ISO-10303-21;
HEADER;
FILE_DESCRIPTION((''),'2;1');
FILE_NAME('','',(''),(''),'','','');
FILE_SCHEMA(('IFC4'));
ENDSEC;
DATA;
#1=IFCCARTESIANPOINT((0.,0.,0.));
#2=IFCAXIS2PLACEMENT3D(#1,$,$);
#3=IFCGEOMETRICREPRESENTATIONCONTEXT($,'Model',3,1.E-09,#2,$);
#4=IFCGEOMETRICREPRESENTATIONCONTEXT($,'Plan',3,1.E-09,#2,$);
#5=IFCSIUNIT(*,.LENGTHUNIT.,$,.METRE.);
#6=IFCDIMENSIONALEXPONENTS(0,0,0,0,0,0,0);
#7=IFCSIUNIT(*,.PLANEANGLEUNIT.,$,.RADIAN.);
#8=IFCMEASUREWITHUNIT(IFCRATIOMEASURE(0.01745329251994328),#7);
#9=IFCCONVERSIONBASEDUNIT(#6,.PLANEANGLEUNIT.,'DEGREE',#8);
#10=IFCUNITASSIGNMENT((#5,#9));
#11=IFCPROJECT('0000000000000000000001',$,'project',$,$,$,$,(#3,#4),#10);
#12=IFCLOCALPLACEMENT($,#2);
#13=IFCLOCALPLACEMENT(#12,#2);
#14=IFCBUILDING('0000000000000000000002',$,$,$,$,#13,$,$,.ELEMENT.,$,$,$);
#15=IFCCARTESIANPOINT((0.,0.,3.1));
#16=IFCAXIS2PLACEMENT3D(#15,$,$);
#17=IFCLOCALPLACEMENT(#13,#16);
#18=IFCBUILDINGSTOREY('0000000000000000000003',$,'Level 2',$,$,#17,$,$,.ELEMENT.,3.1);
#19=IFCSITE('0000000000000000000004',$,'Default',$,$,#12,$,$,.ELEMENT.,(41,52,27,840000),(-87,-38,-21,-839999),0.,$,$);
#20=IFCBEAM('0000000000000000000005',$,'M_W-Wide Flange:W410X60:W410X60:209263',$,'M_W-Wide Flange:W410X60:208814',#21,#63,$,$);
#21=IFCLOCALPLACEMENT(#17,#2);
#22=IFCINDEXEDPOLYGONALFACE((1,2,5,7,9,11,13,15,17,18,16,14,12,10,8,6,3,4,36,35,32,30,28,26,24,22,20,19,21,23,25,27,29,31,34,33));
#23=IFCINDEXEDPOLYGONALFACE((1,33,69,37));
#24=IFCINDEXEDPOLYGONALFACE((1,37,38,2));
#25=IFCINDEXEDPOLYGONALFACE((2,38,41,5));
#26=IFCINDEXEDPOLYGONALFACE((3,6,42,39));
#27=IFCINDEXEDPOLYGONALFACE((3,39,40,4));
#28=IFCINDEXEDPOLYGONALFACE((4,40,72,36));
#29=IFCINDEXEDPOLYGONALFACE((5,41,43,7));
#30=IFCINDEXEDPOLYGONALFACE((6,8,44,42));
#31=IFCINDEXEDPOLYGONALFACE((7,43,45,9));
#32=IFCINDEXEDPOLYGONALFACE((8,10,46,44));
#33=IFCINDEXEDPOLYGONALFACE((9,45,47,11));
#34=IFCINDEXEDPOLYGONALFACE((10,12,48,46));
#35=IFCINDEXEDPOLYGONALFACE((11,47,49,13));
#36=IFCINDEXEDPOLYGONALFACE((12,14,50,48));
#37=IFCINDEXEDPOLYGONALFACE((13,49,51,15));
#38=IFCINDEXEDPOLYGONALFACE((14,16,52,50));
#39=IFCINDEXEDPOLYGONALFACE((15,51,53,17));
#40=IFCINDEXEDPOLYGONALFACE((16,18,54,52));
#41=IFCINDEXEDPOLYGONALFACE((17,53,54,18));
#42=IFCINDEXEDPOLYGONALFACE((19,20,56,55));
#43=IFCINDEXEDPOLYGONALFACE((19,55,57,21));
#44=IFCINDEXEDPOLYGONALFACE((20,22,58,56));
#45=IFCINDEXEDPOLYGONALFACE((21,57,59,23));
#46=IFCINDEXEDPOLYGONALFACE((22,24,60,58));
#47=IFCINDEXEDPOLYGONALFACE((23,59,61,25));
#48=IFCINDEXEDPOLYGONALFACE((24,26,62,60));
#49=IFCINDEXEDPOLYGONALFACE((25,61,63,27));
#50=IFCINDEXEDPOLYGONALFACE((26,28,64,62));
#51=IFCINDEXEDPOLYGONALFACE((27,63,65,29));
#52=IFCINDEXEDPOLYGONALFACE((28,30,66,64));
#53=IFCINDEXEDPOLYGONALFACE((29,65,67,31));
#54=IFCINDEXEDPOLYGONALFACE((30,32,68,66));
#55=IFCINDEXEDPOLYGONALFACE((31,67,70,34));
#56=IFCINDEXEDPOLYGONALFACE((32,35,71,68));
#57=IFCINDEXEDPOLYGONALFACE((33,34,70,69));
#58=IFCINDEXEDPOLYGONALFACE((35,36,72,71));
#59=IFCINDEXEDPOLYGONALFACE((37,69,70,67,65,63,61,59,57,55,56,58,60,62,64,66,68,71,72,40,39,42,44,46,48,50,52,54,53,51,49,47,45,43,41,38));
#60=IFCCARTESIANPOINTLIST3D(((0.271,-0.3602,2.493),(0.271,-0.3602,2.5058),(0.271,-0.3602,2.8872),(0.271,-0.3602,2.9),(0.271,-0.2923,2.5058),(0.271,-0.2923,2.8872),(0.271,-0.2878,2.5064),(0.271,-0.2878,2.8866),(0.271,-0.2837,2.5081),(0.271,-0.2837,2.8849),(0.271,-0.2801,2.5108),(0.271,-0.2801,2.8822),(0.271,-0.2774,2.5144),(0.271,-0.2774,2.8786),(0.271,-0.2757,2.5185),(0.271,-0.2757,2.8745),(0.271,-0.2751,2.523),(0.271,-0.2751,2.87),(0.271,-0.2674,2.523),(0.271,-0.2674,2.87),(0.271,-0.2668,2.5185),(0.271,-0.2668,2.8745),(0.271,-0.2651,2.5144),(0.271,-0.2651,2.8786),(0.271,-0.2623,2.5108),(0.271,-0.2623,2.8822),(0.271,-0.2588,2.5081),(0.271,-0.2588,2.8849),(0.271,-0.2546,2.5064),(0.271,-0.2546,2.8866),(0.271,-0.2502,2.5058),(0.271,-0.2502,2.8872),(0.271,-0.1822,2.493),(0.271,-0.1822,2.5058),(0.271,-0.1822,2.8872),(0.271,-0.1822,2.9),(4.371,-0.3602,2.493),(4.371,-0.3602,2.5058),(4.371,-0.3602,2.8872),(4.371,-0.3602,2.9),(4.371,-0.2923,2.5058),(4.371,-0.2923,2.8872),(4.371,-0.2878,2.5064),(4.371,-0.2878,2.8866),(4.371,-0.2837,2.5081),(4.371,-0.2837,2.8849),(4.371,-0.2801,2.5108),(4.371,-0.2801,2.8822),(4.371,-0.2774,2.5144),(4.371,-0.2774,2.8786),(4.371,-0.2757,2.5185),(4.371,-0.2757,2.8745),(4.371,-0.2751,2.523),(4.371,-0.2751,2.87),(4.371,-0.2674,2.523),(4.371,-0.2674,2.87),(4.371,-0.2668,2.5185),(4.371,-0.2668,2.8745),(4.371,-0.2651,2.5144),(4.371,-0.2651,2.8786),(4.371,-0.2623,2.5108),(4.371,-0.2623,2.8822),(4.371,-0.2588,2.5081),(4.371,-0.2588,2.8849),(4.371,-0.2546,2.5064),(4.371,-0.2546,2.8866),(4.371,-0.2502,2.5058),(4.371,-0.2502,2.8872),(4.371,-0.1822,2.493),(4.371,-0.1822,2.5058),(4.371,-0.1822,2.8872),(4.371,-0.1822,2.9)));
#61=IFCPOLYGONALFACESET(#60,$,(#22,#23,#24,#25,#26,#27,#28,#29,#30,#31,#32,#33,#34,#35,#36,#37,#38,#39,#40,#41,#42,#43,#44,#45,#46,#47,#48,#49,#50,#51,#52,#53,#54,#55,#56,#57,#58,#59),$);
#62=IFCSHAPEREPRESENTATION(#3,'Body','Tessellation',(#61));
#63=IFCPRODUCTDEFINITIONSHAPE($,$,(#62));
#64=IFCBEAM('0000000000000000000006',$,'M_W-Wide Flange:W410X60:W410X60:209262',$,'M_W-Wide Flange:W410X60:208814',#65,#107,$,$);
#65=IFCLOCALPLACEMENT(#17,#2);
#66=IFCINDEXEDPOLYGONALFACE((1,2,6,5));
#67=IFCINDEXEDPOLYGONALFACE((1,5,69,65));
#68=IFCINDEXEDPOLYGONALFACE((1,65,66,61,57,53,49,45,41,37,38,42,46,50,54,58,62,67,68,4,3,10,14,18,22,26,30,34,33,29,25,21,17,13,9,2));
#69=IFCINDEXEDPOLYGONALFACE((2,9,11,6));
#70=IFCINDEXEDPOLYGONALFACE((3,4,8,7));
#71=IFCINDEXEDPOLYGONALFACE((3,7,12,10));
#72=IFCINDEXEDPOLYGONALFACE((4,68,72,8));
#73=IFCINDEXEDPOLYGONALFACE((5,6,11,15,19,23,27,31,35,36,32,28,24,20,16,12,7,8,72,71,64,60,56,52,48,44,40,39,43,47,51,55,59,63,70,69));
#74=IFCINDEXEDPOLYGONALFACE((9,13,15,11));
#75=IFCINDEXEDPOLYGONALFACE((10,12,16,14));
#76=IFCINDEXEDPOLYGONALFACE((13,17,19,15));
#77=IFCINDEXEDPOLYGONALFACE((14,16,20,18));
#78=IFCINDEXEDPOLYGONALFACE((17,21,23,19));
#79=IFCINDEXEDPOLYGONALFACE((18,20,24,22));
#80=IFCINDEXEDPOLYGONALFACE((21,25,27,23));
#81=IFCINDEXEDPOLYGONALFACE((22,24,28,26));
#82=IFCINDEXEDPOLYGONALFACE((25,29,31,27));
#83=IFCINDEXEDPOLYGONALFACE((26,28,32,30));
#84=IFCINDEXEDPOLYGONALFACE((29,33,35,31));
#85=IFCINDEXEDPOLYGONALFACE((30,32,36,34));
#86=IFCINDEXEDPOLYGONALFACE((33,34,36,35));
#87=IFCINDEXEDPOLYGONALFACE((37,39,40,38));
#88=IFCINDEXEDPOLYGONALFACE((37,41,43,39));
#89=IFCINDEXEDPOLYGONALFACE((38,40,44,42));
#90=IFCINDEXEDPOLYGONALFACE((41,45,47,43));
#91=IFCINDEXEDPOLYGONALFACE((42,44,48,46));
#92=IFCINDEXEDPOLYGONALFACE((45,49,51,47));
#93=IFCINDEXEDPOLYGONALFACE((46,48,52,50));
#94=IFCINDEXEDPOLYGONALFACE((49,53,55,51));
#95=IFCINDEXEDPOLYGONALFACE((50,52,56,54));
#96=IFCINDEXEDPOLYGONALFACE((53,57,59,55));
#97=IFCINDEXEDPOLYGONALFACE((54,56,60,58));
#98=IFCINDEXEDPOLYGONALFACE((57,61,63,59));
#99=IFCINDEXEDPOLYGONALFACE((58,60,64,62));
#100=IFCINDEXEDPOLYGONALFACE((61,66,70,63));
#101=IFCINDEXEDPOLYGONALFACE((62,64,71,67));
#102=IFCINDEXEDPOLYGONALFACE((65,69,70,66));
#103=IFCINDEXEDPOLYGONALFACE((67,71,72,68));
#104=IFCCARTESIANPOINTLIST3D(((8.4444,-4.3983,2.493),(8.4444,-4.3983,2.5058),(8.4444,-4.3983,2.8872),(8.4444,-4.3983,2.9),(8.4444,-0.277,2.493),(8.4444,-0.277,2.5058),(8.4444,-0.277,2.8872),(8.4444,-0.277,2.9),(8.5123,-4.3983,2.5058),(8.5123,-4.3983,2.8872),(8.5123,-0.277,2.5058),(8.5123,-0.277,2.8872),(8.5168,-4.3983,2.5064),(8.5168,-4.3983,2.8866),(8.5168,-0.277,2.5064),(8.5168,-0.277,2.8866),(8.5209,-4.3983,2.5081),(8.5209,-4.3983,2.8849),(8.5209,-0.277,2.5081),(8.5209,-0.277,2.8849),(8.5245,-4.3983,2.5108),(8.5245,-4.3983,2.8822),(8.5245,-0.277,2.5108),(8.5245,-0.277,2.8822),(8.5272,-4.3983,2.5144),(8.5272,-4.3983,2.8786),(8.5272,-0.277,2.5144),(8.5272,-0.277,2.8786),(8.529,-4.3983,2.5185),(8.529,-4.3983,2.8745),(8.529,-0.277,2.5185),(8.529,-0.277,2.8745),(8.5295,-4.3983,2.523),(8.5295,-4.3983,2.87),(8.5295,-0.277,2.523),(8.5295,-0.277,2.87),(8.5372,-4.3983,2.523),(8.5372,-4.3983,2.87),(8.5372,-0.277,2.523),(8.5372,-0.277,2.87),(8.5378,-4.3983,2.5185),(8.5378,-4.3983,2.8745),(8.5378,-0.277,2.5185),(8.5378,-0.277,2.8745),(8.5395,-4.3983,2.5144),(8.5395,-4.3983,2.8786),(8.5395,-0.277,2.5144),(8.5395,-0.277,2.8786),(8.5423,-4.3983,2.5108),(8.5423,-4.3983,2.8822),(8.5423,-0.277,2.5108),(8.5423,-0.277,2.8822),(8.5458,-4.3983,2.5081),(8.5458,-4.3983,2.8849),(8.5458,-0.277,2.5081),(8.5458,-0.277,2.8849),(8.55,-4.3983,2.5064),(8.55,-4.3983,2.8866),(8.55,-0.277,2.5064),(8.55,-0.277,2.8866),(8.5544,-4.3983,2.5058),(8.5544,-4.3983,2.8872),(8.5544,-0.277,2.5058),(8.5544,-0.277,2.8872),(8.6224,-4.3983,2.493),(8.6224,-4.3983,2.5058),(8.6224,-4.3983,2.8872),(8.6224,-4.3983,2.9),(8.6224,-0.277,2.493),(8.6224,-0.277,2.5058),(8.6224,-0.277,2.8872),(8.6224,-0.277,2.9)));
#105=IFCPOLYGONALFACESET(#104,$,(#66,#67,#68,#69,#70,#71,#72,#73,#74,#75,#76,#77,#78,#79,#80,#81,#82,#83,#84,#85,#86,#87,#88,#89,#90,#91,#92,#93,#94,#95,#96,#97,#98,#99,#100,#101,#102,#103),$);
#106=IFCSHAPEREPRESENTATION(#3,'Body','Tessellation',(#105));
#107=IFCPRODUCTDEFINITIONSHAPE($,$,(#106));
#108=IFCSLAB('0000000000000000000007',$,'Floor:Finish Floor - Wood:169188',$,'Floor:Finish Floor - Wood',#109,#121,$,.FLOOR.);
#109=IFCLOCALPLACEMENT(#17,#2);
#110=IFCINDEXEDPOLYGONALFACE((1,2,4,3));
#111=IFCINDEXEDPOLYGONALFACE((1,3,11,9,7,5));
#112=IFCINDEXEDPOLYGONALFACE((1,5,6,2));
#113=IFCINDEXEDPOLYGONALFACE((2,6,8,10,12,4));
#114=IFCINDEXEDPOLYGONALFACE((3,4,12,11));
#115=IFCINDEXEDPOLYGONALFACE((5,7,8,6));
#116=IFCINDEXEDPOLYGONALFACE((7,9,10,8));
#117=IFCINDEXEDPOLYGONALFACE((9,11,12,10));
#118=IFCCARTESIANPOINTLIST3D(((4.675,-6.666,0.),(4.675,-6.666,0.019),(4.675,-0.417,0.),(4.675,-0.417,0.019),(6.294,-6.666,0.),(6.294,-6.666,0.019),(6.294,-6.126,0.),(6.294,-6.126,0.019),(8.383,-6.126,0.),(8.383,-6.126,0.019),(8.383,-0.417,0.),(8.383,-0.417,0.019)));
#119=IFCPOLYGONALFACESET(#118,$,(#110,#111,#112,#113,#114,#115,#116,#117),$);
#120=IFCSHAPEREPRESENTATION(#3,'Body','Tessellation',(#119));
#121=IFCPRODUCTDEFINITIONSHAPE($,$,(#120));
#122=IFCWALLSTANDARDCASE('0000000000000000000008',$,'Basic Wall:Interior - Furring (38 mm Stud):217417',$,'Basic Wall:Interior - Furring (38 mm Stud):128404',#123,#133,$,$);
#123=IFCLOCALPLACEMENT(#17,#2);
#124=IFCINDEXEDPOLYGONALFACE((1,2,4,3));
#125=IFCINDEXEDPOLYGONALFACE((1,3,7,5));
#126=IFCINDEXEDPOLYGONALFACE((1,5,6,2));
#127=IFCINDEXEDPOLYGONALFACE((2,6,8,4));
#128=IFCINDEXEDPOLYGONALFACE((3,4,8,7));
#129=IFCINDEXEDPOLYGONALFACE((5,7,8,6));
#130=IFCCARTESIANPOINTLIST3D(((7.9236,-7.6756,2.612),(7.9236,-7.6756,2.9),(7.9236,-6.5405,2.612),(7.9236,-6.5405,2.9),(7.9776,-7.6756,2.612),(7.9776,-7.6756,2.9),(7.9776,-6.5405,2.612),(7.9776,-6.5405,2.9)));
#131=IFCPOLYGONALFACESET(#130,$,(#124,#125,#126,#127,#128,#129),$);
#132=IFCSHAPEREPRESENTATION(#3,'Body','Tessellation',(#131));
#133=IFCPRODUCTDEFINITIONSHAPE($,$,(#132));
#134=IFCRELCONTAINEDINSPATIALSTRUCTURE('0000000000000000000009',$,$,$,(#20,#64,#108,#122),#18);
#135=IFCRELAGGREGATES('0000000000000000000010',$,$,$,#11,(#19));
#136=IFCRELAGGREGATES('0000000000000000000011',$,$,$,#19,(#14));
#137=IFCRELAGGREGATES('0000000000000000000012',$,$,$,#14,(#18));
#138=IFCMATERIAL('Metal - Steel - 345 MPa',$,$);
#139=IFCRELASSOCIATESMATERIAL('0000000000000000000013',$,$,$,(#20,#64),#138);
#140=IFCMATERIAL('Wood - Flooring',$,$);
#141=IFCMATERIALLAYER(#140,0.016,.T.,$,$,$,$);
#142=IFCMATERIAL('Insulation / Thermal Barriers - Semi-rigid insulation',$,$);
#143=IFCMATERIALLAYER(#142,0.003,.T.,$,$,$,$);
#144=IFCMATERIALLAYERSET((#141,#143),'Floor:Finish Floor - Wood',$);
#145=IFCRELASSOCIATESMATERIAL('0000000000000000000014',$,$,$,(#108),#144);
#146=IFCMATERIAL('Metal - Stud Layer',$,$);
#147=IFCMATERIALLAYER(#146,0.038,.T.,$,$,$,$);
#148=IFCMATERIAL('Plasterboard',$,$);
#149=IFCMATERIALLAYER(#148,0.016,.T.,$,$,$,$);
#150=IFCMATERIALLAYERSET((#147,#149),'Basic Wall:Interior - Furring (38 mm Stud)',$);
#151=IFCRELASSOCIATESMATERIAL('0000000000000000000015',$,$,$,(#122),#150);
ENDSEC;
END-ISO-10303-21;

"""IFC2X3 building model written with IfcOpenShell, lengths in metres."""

from ifc_helpers import new_model, entity, si_unit, converted_unit, frame, frame_2d, origin, place, context, project, spatial, polyline, circle_curve, parameter, trimmed, segment, composite_curve, rectangle, outline, extrude, material, layer, layer_set, layer_usage, element, save


model = new_model("IFC2X3")

# Units and contexts
model_context = context("Model", 3, precision=1e-09, world=origin())
plan_context = context("Plan", 3, precision=1e-09, world=origin())
ifc_project = project(units=[si_unit("LENGTHUNIT", "METRE"), converted_unit("PLANEANGLEUNIT", "DEGREE", entity("IfcRatioMeasure", 0.01745329251994328), si_unit("PLANEANGLEUNIT", "RADIAN"), dimensions=[0, 0, 0, 0, 0, 0, 0])], contexts=[model_context, plan_context])

# Site, building, storey
site_placement = place(None, origin())
site = spatial("IfcSite", under=ifc_project, at=site_placement, Name="Default", CompositionType="ELEMENT", RefLatitude=(41, 52, 27, 840000), RefLongitude=(-87, -38, -21, -839999), RefElevation=0.0)
building_placement = place(site_placement, origin())
building = spatial("IfcBuilding", under=site, at=building_placement, CompositionType="ELEMENT")
storey_placement = place(building_placement, frame((0.0, 0.0, 3.1)))
storey = spatial("IfcBuildingStorey", under=building, at=storey_placement, Name="Level 2", CompositionType="ELEMENT", Elevation=3.1)

# Beams
ifc_material_1 = material(Name="Metal - Steel - 345 MPa")
beam_1_placement = place(storey_placement, frame((4.371, -0.2712, 2.9), z_axis=(0.0, 0.0, 1.0), x_axis=(0.0, 1.0, 0.0)))
element("IfcBeam", 1, at=beam_1_placement, inside=storey, material=ifc_material_1, Name="M_W-Wide Flange:W410X60:W410X60:209263", ObjectType="M_W-Wide Flange:W410X60:208814", context=model_context, shape_type="SweptSolid", body=[
    extrude(outline(composite_curve([segment(polyline([(0.1907, -0.089), (0.2035, -0.089)]), True, "CONTINUOUS"), segment(polyline([(0.2035, -0.089), (0.2035, 0.089)]), True, "CONTINUOUS"), segment(polyline([(0.2035, 0.089), (0.1907, 0.089)]), True, "CONTINUOUS"), segment(polyline([(0.1907, 0.089), (0.1907, 0.0211)]), True, "CONTINUOUS"), segment(trimmed(circle_curve(frame_2d((0.1735, 0.0211), x_axis=(1.0, 0.0)), 0.0172), [parameter(270.0)], [parameter(360.0)], True, "PARAMETER"), False, "CONTINUOUS"), segment(polyline([(0.1735, 0.0039), (-0.1735, 0.0039)]), True, "CONTINUOUS"), segment(trimmed(circle_curve(frame_2d((-0.1735, 0.0211), x_axis=(0.0, -1.0)), 0.0172), [parameter(270.0)], [parameter(360.0)], True, "PARAMETER"), False, "CONTINUOUS"), segment(polyline([(-0.1907, 0.0211), (-0.1907, 0.089)]), True, "CONTINUOUS"), segment(polyline([(-0.1907, 0.089), (-0.2035, 0.089)]), True, "CONTINUOUS"), segment(polyline([(-0.2035, 0.089), (-0.2035, -0.089)]), True, "CONTINUOUS"), segment(polyline([(-0.2035, -0.089), (-0.1907, -0.089)]), True, "CONTINUOUS"), segment(polyline([(-0.1907, -0.089), (-0.1907, -0.0211)]), True, "CONTINUOUS"), segment(trimmed(circle_curve(frame_2d((-0.1735, -0.0211), x_axis=(-1.0, 0.0)), 0.0172), [parameter(270.0)], [parameter(0.0)], True, "PARAMETER"), False, "CONTINUOUS"), segment(polyline([(-0.1735, -0.0039), (0.1735, -0.0039)]), True, "CONTINUOUS"), segment(trimmed(circle_curve(frame_2d((0.1735, -0.0211), x_axis=(0.0, 1.0)), 0.0172), [parameter(270.0)], [parameter(0.0)], True, "PARAMETER"), False, "CONTINUOUS"), segment(polyline([(0.1907, -0.0211), (0.1907, -0.089)]), True, "CONTINUOUS")], self_intersect=False)), frame((0.0, 4.1, -0.2035), z_axis=(0.0, -1.0, 0.0), x_axis=(0.0, 0.0, -1.0)), (0.0, 0.0, 1.0), 4.1),
])
beam_2_placement = place(storey_placement, frame((8.5334, -4.3983, 2.9)))
element("IfcBeam", 2, at=beam_2_placement, inside=storey, material=ifc_material_1, Name="M_W-Wide Flange:W410X60:W410X60:209262", ObjectType="M_W-Wide Flange:W410X60:208814", context=model_context, shape_type="SweptSolid", body=[
    extrude(outline(composite_curve([segment(polyline([(-0.089, -0.1907), (-0.089, -0.2035)]), True, "CONTINUOUS"), segment(polyline([(-0.089, -0.2035), (0.089, -0.2035)]), True, "CONTINUOUS"), segment(polyline([(0.089, -0.2035), (0.089, -0.1907)]), True, "CONTINUOUS"), segment(polyline([(0.089, -0.1907), (0.021, -0.1907)]), True, "CONTINUOUS"), segment(trimmed(circle_curve(frame_2d((0.021, -0.1735), x_axis=(0.0, -1.0)), 0.0172), [parameter(270.0)], [parameter(360.0)], True, "PARAMETER"), False, "CONTINUOUS"), segment(polyline([(0.0038, -0.1735), (0.0038, 0.1735)]), True, "CONTINUOUS"), segment(trimmed(circle_curve(frame_2d((0.021, 0.1735), x_axis=(-1.0, 0.0)), 0.0172), [parameter(270.0)], [parameter(360.0)], True, "PARAMETER"), False, "CONTINUOUS"), segment(polyline([(0.021, 0.1907), (0.089, 0.1907)]), True, "CONTINUOUS"), segment(polyline([(0.089, 0.1907), (0.089, 0.2035)]), True, "CONTINUOUS"), segment(polyline([(0.089, 0.2035), (-0.089, 0.2035)]), True, "CONTINUOUS"), segment(polyline([(-0.089, 0.2035), (-0.089, 0.1907)]), True, "CONTINUOUS"), segment(polyline([(-0.089, 0.1907), (-0.0211, 0.1907)]), True, "CONTINUOUS"), segment(trimmed(circle_curve(frame_2d((-0.0211, 0.1735), x_axis=(0.0, 1.0)), 0.0172), [parameter(270.0)], [parameter(0.0)], True, "PARAMETER"), False, "CONTINUOUS"), segment(polyline([(-0.0039, 0.1735), (-0.0039, -0.1735)]), True, "CONTINUOUS"), segment(trimmed(circle_curve(frame_2d((-0.0211, -0.1735), x_axis=(1.0, 0.0)), 0.0172), [parameter(270.0)], [parameter(0.0)], True, "PARAMETER"), False, "CONTINUOUS"), segment(polyline([(-0.0211, -0.1907), (-0.089, -0.1907)]), True, "CONTINUOUS")], self_intersect=False)), frame((0.0, 0.0, -0.2035), z_axis=(0.0, -1.0, 0.0), x_axis=(1.0, 0.0, 0.0)), (0.0, 0.0, -1.0), 4.1213),
])

# Slab
ifc_material_2 = material(Name="Wood - Flooring")
ifc_layer_1 = layer(ifc_material_2, 0.016, ventilated=True)
ifc_material_3 = material(Name="Insulation / Thermal Barriers - Semi-rigid insulation")
ifc_layer_2 = layer(ifc_material_3, 0.003, ventilated=True)
ifc_layer_set_1 = layer_set([ifc_layer_1, ifc_layer_2], Name="Floor:Finish Floor - Wood")
ifc_layer_usage_1 = layer_usage(ifc_layer_set_1, "AXIS3", "POSITIVE", 0.0)
slab_placement = place(storey_placement, frame((4.675, -6.666, 0.0)))
element("IfcSlab", 3, at=slab_placement, inside=storey, material=ifc_layer_usage_1, Name="Floor:Finish Floor - Wood:169188", ObjectType="Floor:Finish Floor - Wood", PredefinedType="FLOOR", context=model_context, shape_type="SweptSolid", body=[
    extrude(outline(polyline([(-1.854, 3.1245), (-1.854, -2.5845), (0.235, -2.5845), (0.235, -3.1245), (1.854, -3.1245), (1.854, 3.1245), (-1.854, 3.1245)])), frame((1.854, 3.1245, 0.019), z_axis=(0.0, 0.0, -1.0), x_axis=(-1.0, 0.0, 0.0)), (0.0, 0.0, 1.0), 0.019),
])

# Wall
ifc_material_4 = material(Name="Metal - Stud Layer")
ifc_layer_3 = layer(ifc_material_4, 0.038, ventilated=True)
ifc_material_5 = material(Name="Plasterboard")
ifc_layer_4 = layer(ifc_material_5, 0.016, ventilated=True)
ifc_layer_set_2 = layer_set([ifc_layer_3, ifc_layer_4], Name="Basic Wall:Interior - Furring (38 mm Stud)")
ifc_layer_usage_2 = layer_usage(ifc_layer_set_2, "AXIS2", "NEGATIVE", 0.027)
wall_1_placement = place(storey_placement, frame((7.9506, -6.5405, 2.612), z_axis=(0.0, 0.0, 1.0), x_axis=(0.0, -1.0, 0.0)))
element("IfcWallStandardCase", 4, at=wall_1_placement, inside=storey, material=ifc_layer_usage_2, Name="Basic Wall:Interior - Furring (38 mm Stud):217417", ObjectType="Basic Wall:Interior - Furring (38 mm Stud):128404", context=model_context, shape_type="SweptSolid", body=[
    extrude(rectangle(XDim=1.1351, YDim=0.054, at=frame_2d((0.5675, 0.0), x_axis=(-1.0, 0.0))), origin(), (0.0, 0.0, 1.0), 0.288),
])

save(model, "model.ifc")
